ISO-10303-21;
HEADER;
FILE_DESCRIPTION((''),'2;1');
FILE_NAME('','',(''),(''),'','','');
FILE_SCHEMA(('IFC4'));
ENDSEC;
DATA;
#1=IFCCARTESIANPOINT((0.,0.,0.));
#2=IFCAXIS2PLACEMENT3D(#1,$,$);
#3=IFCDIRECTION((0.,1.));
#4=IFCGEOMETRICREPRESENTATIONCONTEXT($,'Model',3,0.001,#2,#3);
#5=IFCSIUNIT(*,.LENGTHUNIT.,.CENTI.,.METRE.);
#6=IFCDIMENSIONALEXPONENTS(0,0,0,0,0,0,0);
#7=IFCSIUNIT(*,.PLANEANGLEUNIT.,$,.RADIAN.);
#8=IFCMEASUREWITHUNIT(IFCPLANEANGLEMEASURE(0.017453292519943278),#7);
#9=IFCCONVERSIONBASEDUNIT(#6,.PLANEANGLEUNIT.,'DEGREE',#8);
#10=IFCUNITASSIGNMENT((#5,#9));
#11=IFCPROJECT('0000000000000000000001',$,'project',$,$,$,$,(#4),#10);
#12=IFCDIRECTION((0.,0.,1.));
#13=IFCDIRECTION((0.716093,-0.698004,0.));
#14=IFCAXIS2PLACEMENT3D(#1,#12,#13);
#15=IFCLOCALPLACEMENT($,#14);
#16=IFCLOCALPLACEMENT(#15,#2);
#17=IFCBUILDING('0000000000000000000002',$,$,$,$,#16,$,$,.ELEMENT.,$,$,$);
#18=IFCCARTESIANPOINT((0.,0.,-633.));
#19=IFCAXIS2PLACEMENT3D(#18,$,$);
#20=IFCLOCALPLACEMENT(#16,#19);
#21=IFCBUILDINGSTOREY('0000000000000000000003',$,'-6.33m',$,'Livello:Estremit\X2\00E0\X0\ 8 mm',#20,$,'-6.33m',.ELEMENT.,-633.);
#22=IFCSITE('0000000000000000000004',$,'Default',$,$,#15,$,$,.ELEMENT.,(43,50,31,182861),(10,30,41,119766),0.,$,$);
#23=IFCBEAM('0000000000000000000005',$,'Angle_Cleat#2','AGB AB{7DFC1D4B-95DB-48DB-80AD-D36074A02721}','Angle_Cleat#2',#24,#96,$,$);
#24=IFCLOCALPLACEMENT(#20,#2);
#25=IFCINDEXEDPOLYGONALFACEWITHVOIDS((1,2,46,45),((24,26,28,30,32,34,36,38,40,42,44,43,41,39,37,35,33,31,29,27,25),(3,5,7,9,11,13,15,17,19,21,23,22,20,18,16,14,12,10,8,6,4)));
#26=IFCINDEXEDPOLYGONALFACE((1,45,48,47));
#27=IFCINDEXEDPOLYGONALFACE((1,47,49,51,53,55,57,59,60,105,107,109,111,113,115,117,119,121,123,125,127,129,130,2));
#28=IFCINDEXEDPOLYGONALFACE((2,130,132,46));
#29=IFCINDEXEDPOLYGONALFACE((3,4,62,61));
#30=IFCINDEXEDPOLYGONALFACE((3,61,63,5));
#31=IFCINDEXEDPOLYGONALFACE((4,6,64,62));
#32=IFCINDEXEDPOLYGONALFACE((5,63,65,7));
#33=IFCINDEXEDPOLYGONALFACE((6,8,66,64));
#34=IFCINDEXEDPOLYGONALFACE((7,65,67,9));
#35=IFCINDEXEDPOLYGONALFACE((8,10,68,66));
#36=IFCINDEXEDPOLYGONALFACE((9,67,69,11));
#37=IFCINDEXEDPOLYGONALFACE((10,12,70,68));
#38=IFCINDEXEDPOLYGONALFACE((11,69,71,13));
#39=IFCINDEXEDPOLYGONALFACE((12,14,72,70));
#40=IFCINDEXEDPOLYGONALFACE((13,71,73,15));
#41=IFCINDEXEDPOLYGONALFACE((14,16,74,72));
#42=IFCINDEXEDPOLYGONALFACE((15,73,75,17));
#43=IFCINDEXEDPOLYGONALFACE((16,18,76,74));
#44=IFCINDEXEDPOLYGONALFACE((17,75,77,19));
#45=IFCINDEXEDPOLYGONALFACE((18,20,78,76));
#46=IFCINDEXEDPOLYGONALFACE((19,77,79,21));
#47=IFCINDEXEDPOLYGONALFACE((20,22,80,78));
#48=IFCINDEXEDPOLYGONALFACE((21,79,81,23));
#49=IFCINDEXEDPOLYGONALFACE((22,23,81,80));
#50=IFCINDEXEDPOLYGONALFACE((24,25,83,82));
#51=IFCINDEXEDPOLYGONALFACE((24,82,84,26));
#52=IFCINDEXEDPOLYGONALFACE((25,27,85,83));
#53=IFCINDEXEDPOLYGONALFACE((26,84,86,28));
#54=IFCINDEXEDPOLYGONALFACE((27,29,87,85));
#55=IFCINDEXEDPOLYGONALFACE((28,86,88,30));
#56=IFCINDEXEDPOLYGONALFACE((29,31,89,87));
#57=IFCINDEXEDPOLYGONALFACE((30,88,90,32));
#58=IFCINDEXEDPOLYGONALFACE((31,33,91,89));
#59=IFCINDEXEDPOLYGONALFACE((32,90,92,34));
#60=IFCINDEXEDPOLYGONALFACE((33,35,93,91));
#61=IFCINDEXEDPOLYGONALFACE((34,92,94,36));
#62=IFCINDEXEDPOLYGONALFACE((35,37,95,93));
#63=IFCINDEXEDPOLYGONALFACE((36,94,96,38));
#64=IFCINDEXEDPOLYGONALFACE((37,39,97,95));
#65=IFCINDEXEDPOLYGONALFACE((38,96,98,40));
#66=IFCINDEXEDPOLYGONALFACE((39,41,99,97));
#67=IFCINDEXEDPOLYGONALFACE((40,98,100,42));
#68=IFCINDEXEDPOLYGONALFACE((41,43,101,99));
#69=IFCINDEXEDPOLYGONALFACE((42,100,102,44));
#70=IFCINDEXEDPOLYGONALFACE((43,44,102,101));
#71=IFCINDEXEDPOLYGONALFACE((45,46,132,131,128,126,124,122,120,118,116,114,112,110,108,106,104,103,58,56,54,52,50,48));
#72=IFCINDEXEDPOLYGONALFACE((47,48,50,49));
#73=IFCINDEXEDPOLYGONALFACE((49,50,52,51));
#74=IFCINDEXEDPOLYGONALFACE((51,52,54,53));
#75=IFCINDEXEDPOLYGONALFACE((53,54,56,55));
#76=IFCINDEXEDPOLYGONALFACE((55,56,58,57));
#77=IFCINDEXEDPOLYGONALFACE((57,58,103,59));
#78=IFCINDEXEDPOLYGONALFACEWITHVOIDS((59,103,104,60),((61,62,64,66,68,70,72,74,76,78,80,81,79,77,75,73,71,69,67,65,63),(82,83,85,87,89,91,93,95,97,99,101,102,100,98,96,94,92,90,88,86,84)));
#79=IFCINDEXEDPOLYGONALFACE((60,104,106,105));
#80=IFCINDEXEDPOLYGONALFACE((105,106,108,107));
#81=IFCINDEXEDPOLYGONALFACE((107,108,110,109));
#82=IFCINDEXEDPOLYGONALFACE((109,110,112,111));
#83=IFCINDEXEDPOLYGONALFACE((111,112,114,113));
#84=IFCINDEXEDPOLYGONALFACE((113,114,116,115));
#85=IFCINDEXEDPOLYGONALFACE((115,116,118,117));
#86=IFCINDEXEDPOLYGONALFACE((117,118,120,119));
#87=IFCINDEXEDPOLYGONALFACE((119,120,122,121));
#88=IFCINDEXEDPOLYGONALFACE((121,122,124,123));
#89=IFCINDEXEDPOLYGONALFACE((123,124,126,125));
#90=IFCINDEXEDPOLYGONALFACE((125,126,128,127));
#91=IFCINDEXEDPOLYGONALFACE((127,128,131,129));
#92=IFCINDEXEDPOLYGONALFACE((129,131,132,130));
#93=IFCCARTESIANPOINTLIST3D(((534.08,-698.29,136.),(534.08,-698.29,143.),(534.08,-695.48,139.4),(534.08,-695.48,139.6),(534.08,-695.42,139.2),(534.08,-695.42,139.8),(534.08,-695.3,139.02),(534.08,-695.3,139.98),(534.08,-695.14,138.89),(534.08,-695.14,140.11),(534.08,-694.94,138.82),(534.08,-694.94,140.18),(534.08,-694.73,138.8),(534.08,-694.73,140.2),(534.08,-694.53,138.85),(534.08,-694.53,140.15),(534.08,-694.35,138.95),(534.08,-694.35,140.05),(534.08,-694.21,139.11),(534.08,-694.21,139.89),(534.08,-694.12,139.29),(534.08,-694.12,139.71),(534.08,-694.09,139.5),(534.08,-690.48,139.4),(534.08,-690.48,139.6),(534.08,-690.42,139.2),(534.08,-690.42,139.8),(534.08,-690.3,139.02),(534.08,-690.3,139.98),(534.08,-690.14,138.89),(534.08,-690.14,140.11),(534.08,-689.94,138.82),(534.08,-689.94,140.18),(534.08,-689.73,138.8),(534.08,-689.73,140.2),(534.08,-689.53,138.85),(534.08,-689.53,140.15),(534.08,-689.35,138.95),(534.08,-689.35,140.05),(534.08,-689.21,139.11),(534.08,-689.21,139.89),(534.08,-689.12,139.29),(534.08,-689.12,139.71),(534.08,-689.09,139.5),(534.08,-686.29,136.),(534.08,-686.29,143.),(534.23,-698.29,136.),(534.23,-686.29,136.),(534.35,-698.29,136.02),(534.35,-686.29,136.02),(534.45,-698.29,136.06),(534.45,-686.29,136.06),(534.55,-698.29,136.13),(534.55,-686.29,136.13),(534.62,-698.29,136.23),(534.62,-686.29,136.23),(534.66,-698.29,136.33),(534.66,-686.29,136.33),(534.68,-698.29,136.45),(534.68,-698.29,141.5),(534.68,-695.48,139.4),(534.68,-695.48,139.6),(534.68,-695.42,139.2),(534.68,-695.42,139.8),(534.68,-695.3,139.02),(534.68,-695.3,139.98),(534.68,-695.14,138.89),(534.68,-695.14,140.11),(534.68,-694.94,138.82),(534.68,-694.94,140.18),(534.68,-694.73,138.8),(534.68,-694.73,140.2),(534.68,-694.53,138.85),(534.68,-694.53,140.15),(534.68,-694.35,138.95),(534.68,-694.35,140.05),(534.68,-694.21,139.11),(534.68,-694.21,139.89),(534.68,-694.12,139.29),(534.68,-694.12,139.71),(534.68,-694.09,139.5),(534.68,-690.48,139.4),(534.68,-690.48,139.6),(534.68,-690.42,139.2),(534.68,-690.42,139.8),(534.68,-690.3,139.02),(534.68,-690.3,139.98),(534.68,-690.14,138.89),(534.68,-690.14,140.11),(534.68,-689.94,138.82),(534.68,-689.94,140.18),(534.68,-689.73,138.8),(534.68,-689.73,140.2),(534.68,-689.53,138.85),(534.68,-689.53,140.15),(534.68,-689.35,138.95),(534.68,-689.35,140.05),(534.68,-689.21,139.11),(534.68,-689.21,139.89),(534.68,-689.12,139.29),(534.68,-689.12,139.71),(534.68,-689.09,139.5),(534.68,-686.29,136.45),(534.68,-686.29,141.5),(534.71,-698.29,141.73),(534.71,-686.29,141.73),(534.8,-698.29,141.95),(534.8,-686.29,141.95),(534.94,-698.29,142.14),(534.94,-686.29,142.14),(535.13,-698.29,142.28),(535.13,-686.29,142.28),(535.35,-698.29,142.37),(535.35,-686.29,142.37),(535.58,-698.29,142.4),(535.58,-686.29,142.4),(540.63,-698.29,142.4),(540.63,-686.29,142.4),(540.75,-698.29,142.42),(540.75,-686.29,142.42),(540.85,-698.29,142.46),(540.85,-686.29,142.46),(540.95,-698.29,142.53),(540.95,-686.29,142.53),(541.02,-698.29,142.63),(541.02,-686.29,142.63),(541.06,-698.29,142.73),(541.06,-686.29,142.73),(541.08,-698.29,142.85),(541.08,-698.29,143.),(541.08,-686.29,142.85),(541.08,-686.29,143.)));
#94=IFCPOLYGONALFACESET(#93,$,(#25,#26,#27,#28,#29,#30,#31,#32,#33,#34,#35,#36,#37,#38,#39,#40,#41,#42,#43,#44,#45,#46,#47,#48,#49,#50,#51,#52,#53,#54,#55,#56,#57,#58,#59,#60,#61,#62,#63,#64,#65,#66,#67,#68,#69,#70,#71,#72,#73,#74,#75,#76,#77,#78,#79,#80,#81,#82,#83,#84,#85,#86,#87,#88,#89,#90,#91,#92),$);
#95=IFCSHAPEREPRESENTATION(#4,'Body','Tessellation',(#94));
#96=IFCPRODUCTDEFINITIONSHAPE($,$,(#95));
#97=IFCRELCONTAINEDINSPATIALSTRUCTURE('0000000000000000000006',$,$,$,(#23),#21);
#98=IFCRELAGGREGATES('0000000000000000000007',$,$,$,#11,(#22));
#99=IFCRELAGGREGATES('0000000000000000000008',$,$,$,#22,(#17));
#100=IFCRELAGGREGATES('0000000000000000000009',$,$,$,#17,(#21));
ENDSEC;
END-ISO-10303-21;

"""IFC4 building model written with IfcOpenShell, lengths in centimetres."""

from ifc_helpers import new_model, entity, si_unit, converted_unit, direction, frame, frame_2d, origin, place, context, project, spatial, circle, l_section, extrude, element, save


model = new_model("IFC4")

# Units and contexts
model_context = context("Model", 3, precision=0.001, world=origin(), true_north=direction((0.0, 1.0)))
ifc_project = project(units=[si_unit("LENGTHUNIT", "METRE", prefix="CENTI"), converted_unit("PLANEANGLEUNIT", "DEGREE", entity("IfcPlaneAngleMeasure", 0.017453292519943278), si_unit("PLANEANGLEUNIT", "RADIAN"), dimensions=[0, 0, 0, 0, 0, 0, 0])], contexts=[model_context])

# Site, building, storey
site_placement = place(None, frame((0.0, 0.0, 0.0), z_axis=(0.0, 0.0, 1.0), x_axis=(0.716093, -0.698004, 0.0)))
site = spatial("IfcSite", under=ifc_project, at=site_placement, Name="Default", CompositionType="ELEMENT", RefLatitude=(43, 50, 31, 182861), RefLongitude=(10, 30, 41, 119766), RefElevation=0.0)
building_placement = place(site_placement, origin())
building = spatial("IfcBuilding", under=site, at=building_placement, CompositionType="ELEMENT")
storey_placement = place(building_placement, frame((0.0, 0.0, -633.0)))
storey = spatial("IfcBuildingStorey", under=building, at=storey_placement, Name="-6.33m", ObjectType="Livello:Estremità 8 mm", LongName="-6.33m", CompositionType="ELEMENT", Elevation=-633.0)

# Beam, openings
beam_placement = place(storey_placement, frame((536.01, -686.29, 141.07), z_axis=(0.0, 1.0, 0.0), x_axis=(1.0, 0.0, 0.0)))
beam = element("IfcBeam", 1, at=beam_placement, inside=storey, Name="Angle_Cleat#2", Description="AGB AB{7DFC1D4B-95DB-48DB-80AD-D36074A02721}", ObjectType="Angle_Cleat#2", context=model_context, shape_type="SweptSolid", body=[
    extrude(l_section(Depth=7.0, Width=7.0, Thickness=0.6, FilletRadius=0.9, EdgeRadius=0.45, at=frame_2d((1.57, 1.57))), origin(), (0.0, 0.0, -1.0), 12.0),
])
opening_1_placement = place(beam_placement, frame((-1.98, 1.57, -6.0), z_axis=(1.0, 0.0, 0.0), x_axis=(0.0, 0.0, 1.0)))
element("IfcOpeningElement", 2, at=opening_1_placement, cuts=beam, ObjectType="Opening", context=model_context, shape_type="SweptSolid", body=[
    extrude(circle(Radius=0.7, at=frame_2d((2.5, 0.0), x_axis=(1.0, 0.0))), origin(), (0.0, 0.0, 1.0), 0.7),
])
opening_2_placement = place(beam_placement, frame((-1.98, 1.57, -6.0), z_axis=(1.0, 0.0, 0.0), x_axis=(0.0, 0.0, 1.0)))
element("IfcOpeningElement", 3, at=opening_2_placement, cuts=beam, ObjectType="Opening", context=model_context, shape_type="SweptSolid", body=[
    extrude(circle(Radius=0.7, at=frame_2d((-2.5, 0.0), x_axis=(1.0, 0.0))), origin(), (0.0, 0.0, 1.0), 0.7),
])

save(model, "model.ifc")
